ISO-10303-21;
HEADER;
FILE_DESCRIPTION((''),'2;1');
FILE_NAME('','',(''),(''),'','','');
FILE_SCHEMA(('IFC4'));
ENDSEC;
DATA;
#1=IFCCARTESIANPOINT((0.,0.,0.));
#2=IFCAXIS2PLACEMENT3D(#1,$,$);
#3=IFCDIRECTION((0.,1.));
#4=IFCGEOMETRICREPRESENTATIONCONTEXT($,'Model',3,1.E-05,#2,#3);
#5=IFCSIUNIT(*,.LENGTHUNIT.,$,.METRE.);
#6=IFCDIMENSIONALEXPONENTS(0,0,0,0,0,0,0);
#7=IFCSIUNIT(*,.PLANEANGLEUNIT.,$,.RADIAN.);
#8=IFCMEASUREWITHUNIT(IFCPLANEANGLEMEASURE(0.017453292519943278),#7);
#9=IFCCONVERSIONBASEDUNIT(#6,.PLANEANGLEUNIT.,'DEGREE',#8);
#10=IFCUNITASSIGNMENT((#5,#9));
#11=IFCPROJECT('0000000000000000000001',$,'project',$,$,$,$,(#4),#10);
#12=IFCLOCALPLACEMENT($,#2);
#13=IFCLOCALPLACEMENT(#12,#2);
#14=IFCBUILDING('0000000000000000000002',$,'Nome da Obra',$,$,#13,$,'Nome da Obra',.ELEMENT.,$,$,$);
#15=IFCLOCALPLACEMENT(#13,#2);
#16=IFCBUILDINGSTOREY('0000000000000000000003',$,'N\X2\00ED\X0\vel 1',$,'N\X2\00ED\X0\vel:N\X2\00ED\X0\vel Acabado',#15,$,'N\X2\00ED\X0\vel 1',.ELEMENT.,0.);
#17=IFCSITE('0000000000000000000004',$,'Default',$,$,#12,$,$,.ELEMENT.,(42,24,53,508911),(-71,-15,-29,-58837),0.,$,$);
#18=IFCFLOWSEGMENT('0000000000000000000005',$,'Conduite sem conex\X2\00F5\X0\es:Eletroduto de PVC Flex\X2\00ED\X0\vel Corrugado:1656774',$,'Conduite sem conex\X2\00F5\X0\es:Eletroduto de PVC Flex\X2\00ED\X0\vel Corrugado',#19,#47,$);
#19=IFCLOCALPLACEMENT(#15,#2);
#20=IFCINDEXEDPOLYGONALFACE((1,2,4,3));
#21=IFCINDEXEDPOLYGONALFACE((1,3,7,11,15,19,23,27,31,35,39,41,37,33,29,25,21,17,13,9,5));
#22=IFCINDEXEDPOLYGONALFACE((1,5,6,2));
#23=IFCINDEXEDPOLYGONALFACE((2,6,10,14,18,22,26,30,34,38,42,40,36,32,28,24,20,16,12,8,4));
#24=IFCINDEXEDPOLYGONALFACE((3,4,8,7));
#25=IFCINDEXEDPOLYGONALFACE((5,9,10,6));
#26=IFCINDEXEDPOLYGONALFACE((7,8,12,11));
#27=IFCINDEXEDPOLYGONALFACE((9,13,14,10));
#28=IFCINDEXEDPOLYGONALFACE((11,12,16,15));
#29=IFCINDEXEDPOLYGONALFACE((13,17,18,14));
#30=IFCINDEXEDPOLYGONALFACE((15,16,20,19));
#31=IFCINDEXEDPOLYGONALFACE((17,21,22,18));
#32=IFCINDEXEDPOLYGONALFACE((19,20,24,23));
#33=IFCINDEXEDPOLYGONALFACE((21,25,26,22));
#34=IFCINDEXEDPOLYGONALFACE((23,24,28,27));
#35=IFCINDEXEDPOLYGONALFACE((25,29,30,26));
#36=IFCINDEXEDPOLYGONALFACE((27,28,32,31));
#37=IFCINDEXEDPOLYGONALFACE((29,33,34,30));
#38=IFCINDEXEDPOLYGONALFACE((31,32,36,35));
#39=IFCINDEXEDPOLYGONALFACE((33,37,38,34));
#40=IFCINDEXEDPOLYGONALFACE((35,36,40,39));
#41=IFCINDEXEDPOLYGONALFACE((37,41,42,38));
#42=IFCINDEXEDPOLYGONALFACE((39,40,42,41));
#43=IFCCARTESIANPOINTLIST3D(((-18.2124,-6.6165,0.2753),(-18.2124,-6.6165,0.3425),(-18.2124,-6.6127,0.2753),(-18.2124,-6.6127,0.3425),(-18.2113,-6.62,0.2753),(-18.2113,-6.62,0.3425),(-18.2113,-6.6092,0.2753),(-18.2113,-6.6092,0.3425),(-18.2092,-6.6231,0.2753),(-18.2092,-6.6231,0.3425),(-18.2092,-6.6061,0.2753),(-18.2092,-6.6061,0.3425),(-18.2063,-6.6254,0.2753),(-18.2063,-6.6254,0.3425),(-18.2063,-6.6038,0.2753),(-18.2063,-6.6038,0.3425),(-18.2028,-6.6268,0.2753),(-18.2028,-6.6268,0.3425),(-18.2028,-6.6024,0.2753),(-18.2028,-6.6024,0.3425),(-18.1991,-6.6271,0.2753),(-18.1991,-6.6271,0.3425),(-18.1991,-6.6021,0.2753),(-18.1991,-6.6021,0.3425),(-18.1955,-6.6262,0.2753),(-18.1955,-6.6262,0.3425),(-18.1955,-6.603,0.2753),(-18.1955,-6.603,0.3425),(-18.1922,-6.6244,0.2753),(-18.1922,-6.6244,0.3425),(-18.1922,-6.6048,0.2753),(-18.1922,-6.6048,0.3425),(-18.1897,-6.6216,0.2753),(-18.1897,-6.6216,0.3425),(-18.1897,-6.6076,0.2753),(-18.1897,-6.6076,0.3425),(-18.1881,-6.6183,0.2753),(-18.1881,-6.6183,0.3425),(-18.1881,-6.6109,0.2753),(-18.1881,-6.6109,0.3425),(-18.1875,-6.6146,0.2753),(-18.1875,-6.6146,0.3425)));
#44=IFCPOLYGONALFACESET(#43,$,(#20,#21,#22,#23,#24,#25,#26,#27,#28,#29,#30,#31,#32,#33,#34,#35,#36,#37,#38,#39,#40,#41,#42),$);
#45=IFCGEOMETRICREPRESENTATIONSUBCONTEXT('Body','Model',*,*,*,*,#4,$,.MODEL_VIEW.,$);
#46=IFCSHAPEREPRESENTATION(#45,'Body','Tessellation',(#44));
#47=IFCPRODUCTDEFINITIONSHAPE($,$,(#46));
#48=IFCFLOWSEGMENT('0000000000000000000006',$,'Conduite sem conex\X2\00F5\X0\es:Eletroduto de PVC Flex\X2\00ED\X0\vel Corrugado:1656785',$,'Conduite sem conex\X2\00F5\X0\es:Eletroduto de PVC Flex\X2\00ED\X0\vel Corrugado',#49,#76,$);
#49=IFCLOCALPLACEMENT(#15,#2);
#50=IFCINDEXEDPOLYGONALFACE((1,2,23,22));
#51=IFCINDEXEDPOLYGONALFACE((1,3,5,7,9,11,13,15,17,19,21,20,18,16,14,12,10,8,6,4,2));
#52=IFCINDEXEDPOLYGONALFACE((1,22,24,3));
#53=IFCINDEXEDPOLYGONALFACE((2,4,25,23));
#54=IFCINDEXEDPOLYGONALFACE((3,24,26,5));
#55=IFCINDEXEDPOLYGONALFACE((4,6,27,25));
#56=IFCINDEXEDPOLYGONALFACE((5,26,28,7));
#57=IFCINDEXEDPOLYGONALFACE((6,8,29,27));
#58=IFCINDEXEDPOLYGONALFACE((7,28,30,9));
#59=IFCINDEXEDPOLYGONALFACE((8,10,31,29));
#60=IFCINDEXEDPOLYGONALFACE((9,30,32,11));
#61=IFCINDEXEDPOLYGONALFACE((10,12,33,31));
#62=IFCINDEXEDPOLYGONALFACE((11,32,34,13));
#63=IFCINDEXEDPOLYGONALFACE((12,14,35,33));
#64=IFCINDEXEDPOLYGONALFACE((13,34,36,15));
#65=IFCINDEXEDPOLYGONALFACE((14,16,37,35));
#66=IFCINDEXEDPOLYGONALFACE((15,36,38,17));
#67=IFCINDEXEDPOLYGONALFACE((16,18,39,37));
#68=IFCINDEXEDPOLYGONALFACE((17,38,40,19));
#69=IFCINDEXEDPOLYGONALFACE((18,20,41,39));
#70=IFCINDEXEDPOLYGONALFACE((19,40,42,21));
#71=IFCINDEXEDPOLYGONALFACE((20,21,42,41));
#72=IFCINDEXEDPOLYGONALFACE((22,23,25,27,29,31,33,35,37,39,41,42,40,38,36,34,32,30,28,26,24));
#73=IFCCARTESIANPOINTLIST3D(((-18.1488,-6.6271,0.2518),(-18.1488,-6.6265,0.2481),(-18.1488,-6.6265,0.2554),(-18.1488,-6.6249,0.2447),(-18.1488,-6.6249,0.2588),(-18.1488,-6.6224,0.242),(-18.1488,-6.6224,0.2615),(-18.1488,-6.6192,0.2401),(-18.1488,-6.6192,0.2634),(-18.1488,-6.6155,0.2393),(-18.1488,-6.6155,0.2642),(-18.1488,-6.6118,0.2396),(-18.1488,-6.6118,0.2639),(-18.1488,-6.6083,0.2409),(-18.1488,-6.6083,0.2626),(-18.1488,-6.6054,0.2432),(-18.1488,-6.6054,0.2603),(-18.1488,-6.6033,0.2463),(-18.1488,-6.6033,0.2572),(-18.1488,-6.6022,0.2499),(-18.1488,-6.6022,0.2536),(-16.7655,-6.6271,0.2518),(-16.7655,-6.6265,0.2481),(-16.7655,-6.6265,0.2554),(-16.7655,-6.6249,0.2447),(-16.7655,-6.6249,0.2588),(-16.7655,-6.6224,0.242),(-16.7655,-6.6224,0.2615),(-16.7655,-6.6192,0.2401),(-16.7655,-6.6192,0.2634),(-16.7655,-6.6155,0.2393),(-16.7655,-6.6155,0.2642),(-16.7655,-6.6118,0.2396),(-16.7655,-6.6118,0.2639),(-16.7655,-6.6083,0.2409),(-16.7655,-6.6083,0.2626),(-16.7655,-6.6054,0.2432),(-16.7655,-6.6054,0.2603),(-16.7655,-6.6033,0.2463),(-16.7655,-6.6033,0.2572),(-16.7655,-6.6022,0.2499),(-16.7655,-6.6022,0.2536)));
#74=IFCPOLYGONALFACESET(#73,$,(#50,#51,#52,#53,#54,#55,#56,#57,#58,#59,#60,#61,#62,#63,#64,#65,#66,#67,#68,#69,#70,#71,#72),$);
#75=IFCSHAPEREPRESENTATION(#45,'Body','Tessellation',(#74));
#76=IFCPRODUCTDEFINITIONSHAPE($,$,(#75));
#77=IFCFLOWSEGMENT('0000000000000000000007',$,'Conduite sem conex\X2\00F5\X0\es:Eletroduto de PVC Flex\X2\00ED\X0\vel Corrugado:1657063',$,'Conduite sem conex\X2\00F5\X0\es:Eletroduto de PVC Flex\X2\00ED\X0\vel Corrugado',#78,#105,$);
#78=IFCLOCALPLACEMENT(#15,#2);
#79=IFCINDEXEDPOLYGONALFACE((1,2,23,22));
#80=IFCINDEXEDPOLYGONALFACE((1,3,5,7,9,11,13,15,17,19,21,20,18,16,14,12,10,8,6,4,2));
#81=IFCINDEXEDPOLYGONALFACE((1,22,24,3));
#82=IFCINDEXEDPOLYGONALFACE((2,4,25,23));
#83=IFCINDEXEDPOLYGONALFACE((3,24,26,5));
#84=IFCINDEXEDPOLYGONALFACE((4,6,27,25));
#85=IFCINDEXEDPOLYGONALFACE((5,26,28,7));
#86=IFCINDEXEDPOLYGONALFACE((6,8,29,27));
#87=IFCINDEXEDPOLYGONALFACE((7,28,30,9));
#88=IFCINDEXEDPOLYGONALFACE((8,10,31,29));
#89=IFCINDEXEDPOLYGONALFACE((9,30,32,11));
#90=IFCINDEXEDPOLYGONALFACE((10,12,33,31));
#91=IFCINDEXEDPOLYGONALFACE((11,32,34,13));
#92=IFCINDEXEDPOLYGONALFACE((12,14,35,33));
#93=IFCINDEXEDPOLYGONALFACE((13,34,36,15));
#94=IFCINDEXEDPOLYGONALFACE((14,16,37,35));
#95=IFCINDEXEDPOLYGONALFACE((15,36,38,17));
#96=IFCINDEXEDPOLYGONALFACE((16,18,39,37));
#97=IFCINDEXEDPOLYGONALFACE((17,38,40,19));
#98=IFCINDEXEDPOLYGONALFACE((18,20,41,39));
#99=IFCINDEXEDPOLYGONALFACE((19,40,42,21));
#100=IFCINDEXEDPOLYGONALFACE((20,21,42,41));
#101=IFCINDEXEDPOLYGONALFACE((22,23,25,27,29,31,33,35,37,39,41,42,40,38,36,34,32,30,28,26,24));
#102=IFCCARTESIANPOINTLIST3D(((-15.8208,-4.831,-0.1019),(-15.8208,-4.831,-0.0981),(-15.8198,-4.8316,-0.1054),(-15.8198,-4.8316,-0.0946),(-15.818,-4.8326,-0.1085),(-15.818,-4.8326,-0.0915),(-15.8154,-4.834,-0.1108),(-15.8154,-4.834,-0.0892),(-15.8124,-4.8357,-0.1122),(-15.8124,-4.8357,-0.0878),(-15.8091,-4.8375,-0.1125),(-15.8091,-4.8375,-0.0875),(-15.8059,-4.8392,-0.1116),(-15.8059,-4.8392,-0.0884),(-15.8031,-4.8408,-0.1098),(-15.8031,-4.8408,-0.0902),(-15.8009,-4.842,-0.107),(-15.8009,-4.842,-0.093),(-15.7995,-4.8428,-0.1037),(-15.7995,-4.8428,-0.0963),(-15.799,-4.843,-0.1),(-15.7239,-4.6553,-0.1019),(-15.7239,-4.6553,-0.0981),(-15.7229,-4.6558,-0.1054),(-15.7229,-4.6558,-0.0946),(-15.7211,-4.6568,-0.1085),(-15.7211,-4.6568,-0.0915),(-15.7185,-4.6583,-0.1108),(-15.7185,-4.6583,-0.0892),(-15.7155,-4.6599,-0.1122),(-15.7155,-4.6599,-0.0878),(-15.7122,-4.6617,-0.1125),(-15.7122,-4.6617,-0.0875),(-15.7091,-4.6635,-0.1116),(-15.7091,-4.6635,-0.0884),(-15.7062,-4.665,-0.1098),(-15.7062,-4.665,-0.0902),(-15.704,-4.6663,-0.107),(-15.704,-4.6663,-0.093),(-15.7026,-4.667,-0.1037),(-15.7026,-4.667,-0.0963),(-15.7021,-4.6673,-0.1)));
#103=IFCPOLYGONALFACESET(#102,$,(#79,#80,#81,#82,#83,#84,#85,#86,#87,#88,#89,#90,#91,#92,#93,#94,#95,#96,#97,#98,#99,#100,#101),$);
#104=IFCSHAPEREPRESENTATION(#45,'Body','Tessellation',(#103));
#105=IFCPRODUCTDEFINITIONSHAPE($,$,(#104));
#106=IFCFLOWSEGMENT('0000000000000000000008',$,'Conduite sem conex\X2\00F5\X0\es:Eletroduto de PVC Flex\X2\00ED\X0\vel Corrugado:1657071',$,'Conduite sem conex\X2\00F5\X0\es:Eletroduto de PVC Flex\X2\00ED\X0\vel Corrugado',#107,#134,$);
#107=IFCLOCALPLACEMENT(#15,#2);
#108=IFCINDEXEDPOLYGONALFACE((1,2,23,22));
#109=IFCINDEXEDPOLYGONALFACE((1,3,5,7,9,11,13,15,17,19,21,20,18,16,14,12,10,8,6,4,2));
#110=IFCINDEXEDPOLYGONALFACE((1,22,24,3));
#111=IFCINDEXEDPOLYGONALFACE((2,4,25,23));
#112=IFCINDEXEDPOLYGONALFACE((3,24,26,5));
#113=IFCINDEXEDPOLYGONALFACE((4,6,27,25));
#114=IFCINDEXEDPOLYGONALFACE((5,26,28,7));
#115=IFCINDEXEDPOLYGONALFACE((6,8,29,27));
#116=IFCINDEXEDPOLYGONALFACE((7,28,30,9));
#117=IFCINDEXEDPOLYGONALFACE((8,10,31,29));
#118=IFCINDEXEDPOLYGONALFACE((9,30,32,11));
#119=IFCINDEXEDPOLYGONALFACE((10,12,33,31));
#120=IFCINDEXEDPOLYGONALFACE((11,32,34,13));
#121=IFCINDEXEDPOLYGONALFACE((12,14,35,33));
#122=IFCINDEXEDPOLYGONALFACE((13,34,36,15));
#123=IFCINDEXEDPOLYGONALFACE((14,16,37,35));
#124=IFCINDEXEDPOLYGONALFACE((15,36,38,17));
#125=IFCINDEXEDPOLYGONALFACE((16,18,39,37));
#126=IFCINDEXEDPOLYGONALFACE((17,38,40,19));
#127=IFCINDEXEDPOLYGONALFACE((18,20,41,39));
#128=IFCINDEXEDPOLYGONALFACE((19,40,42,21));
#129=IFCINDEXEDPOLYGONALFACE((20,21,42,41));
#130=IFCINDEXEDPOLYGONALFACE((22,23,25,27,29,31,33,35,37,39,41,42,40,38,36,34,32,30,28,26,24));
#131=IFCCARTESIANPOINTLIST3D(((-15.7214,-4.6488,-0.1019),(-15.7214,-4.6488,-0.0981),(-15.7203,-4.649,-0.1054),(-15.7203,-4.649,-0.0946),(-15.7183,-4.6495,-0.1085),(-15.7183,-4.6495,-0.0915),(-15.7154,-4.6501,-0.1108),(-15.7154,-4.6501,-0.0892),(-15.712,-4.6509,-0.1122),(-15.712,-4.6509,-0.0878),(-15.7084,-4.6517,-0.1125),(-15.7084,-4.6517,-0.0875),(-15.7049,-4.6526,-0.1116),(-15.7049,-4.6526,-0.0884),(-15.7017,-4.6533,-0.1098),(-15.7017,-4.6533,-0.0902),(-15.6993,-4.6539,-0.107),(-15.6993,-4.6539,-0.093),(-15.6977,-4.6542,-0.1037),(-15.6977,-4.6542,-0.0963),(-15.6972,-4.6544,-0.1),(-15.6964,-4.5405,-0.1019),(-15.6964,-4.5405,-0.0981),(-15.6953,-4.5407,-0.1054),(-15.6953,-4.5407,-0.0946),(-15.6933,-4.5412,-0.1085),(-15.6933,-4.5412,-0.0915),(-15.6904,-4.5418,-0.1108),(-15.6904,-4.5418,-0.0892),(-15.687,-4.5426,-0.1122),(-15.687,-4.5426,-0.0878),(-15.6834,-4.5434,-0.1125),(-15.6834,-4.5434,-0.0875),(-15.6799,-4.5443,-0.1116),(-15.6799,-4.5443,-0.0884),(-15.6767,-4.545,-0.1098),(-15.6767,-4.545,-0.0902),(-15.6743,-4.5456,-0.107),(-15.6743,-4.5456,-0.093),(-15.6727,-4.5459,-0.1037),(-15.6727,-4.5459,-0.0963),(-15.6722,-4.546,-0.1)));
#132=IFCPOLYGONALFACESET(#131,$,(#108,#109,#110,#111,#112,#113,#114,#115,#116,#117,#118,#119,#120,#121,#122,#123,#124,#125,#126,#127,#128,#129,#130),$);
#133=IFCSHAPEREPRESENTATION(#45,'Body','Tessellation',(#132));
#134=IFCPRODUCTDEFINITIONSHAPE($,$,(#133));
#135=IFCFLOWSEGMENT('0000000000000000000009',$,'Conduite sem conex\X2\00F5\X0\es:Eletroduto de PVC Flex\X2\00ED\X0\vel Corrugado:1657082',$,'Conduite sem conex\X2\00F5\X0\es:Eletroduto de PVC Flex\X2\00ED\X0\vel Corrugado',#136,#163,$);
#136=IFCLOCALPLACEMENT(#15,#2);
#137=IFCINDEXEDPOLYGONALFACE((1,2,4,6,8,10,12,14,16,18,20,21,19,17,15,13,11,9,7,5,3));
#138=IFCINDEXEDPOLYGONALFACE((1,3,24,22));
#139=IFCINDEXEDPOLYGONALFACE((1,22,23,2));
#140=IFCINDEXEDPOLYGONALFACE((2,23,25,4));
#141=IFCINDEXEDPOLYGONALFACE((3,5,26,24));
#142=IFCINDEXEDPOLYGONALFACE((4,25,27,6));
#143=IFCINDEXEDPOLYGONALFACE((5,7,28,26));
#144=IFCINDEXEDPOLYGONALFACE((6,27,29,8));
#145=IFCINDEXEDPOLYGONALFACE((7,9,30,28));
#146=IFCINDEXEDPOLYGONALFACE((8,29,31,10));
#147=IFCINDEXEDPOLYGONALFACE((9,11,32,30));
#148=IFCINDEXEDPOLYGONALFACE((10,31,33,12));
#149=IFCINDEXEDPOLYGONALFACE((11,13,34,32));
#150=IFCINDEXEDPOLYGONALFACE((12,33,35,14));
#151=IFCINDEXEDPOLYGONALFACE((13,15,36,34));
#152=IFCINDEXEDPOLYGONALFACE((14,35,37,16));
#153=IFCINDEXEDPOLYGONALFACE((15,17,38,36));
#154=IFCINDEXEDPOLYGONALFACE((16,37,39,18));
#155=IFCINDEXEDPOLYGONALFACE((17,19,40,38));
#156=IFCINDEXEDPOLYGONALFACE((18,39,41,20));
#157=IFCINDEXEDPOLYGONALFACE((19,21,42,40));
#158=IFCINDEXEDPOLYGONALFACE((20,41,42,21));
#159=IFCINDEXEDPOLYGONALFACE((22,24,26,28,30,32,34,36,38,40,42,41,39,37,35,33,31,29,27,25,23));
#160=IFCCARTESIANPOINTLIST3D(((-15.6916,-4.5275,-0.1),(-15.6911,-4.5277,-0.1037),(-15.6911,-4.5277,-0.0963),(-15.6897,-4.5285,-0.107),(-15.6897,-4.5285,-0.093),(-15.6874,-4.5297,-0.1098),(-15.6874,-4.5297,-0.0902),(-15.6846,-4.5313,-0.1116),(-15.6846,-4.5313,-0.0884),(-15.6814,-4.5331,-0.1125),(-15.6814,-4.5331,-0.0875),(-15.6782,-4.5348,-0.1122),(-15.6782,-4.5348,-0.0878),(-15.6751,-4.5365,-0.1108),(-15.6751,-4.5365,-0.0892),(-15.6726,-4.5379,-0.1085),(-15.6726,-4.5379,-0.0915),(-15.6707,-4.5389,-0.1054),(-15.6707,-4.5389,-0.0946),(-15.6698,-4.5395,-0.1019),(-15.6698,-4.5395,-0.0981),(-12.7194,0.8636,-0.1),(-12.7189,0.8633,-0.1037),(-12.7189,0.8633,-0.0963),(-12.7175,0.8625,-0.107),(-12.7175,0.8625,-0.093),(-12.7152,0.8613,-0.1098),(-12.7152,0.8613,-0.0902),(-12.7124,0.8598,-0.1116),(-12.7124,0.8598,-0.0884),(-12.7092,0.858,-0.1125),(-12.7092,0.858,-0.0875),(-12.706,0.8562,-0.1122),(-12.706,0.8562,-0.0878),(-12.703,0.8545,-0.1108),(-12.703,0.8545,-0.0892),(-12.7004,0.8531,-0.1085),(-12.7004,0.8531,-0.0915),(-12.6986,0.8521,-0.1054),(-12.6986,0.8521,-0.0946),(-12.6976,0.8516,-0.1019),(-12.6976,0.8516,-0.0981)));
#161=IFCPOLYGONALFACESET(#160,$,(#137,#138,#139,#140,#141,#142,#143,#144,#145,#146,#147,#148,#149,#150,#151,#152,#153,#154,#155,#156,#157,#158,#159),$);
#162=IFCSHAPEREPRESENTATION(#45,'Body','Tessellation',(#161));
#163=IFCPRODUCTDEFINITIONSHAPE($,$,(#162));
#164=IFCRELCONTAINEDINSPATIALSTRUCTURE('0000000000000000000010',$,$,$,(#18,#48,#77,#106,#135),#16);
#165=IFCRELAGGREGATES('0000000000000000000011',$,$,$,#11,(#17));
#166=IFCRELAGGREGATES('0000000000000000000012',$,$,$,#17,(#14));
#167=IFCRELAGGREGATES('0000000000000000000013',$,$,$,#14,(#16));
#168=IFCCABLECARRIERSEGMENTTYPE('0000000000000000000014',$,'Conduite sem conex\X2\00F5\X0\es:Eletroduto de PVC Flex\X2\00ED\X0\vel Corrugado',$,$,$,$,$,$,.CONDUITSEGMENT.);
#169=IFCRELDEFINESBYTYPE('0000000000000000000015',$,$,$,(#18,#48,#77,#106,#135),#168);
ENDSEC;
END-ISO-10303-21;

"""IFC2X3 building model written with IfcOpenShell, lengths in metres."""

from ifc_helpers import new_model, entity, si_unit, converted_unit, direction, frame, frame_2d, origin, origin_2d_with_axis, place, context, subcontext, project, spatial, circle, extrude, type_object, element, save


model = new_model("IFC2X3")

# Units and contexts
model_context = context("Model", 3, precision=1e-05, world=origin(), true_north=direction((0.0, 1.0)))
body_context = subcontext(model_context, "Body", "Model", "MODEL_VIEW")
ifc_project = project(units=[si_unit("LENGTHUNIT", "METRE"), converted_unit("PLANEANGLEUNIT", "DEGREE", entity("IfcPlaneAngleMeasure", 0.017453292519943278), si_unit("PLANEANGLEUNIT", "RADIAN"), dimensions=[0, 0, 0, 0, 0, 0, 0])], contexts=[model_context])

# Site, building, storey
site_placement = place(None, origin())
site = spatial("IfcSite", under=ifc_project, at=site_placement, Name="Default", CompositionType="ELEMENT", RefLatitude=(42, 24, 53, 508911), RefLongitude=(-71, -15, -29, -58837), RefElevation=0.0)
building_placement = place(site_placement, origin())
building = spatial("IfcBuilding", under=site, at=building_placement, Name="Nome da Obra", LongName="Nome da Obra", CompositionType="ELEMENT")
storey_placement = place(building_placement, origin())
storey = spatial("IfcBuildingStorey", under=building, at=storey_placement, Name="Nível 1", ObjectType="Nível:Nível Acabado", LongName="Nível 1", CompositionType="ELEMENT", Elevation=0.0)

# Flow segments
cable_carrier_segment_type = type_object("IfcCableCarrierSegmentType", Name="Conduite sem conexões:Eletroduto de PVC Flexível Corrugado", PredefinedType="CONDUITSEGMENT")
flow_segment_1_placement = place(storey_placement, origin())
element("IfcFlowSegment", 1, at=flow_segment_1_placement, inside=storey, type_object=cable_carrier_segment_type, Name="Conduite sem conexões:Eletroduto de PVC Flexível Corrugado:1656774", ObjectType="Conduite sem conexões:Eletroduto de PVC Flexível Corrugado", context=body_context, shape_type="SweptSolid", body=[
    extrude(circle(Radius=0.0125, at=frame_2d((0.0, 0.0), x_axis=(1.0, 0.0))), frame((-18.2, -6.6146, 0.2753)), (0.0, 0.0, 1.0), 0.0672),
])
flow_segment_2_placement = place(storey_placement, origin())
element("IfcFlowSegment", 2, at=flow_segment_2_placement, inside=storey, type_object=cable_carrier_segment_type, Name="Conduite sem conexões:Eletroduto de PVC Flexível Corrugado:1656785", ObjectType="Conduite sem conexões:Eletroduto de PVC Flexível Corrugado", context=body_context, shape_type="SweptSolid", body=[
    extrude(circle(Radius=0.0125, at=origin_2d_with_axis()), frame((-18.1488, -6.6146, 0.2518), z_axis=(1.0, -0.000002, 0.0), x_axis=(-0.000002, -1.0, 0.0)), (0.0, 0.0, 1.0), 1.3833),
])
flow_segment_3_placement = place(storey_placement, origin())
element("IfcFlowSegment", 3, at=flow_segment_3_placement, inside=storey, type_object=cable_carrier_segment_type, Name="Conduite sem conexões:Eletroduto de PVC Flexível Corrugado:1657063", ObjectType="Conduite sem conexões:Eletroduto de PVC Flexível Corrugado", context=body_context, shape_type="SweptSolid", body=[
    extrude(circle(Radius=0.0125, at=frame_2d((0.0, 0.0), x_axis=(1.0, 0.0))), frame((-15.8099, -4.837, -0.1), z_axis=(0.482805, 0.875728, 0.0), x_axis=(0.875728, -0.482805, 0.0)), (0.0, 0.0, 1.0), 0.2007),
])
flow_segment_4_placement = place(storey_placement, origin())
element("IfcFlowSegment", 4, at=flow_segment_4_placement, inside=storey, type_object=cable_carrier_segment_type, Name="Conduite sem conexões:Eletroduto de PVC Flexível Corrugado:1657071", ObjectType="Conduite sem conexões:Eletroduto de PVC Flexível Corrugado", context=body_context, shape_type="SweptSolid", body=[
    extrude(circle(Radius=0.0125, at=frame_2d((0.0, 0.0), x_axis=(1.0, 0.0))), frame((-15.7093, -4.6515, -0.1), z_axis=(0.224974, 0.974365, 0.0), x_axis=(0.974365, -0.224974, 0.0)), (0.0, 0.0, 1.0), 0.1112),
])
flow_segment_5_placement = place(storey_placement, origin())
element("IfcFlowSegment", 5, at=flow_segment_5_placement, inside=storey, type_object=cable_carrier_segment_type, Name="Conduite sem conexões:Eletroduto de PVC Flexível Corrugado:1657082", ObjectType="Conduite sem conexões:Eletroduto de PVC Flexível Corrugado", context=body_context, shape_type="SweptSolid", body=[
    extrude(circle(Radius=0.0125, at=frame_2d((0.0, 0.0), x_axis=(1.0, 0.0))), frame((-15.6806, -4.5335, -0.1), z_axis=(0.482805, 0.875728, 0.0), x_axis=(-0.875728, 0.482805, 0.0)), (0.0, 0.0, 1.0), 6.1561),
])

save(model, "model.ifc")
